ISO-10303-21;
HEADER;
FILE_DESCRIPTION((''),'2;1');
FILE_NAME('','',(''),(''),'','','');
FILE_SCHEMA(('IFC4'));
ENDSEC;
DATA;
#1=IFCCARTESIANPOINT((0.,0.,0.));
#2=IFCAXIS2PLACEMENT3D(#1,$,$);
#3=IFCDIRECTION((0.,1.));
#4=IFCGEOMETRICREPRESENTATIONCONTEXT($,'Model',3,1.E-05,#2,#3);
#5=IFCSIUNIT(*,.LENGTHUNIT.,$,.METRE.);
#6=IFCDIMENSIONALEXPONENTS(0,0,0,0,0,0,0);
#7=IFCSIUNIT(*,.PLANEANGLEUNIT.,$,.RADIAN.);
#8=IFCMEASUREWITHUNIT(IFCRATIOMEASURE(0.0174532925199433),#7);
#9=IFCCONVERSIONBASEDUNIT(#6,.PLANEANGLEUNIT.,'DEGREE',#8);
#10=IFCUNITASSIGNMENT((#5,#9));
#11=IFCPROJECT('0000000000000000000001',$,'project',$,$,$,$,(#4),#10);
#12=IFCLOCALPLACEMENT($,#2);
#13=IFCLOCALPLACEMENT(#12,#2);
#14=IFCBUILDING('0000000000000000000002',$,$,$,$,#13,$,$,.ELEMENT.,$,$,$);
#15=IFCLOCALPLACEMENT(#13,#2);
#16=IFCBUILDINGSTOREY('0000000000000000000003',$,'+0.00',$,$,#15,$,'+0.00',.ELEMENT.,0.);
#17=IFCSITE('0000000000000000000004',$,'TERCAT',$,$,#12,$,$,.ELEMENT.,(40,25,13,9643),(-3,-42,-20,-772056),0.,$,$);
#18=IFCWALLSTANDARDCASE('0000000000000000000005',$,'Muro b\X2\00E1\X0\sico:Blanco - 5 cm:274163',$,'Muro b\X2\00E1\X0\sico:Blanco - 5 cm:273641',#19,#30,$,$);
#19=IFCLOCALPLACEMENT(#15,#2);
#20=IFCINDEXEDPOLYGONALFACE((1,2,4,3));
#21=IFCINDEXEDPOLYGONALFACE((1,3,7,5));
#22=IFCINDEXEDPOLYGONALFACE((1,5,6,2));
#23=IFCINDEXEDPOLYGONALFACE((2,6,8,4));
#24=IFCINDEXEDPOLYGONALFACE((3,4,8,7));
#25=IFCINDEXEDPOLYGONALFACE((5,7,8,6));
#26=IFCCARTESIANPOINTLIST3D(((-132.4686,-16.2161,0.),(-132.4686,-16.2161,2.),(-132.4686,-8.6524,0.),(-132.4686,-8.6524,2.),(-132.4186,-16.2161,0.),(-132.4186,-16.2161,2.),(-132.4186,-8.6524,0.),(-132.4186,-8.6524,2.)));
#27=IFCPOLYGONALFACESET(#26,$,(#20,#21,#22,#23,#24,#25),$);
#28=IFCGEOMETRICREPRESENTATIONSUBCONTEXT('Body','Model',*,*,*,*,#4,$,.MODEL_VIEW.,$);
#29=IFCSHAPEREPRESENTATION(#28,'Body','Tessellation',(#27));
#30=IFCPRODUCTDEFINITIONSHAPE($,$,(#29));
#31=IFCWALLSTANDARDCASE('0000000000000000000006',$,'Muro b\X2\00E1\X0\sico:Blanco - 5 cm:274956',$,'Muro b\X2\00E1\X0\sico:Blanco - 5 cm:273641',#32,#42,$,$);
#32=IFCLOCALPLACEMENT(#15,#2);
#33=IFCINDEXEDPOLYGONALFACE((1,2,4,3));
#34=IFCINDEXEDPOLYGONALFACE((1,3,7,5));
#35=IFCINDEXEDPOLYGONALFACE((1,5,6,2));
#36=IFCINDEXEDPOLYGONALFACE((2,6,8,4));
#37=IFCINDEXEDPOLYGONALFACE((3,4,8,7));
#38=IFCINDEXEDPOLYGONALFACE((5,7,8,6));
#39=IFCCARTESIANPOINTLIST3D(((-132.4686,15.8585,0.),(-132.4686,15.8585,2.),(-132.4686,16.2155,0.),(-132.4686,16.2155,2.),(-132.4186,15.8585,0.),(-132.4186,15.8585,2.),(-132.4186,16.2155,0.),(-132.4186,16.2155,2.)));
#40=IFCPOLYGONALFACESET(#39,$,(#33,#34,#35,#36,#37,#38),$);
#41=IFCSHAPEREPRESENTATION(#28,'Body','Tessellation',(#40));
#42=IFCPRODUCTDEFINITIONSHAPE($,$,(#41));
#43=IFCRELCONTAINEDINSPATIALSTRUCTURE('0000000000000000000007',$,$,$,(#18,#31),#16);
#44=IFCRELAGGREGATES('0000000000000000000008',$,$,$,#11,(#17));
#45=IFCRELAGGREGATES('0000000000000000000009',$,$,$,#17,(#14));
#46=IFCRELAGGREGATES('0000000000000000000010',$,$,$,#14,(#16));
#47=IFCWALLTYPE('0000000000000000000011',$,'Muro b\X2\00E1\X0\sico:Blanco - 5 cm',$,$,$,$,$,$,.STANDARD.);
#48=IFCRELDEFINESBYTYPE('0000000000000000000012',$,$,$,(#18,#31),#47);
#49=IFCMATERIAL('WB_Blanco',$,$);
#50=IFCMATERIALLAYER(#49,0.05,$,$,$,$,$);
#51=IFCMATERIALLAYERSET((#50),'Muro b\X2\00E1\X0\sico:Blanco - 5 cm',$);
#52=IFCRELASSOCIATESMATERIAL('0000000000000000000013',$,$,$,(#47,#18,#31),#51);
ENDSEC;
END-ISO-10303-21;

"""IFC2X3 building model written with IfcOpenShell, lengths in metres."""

from ifc_helpers import new_model, entity, si_unit, converted_unit, direction, frame, frame_2d, origin, place, context, subcontext, project, spatial, rectangle, extrude, material, layer, layer_set, layer_usage, type_object, element, save


model = new_model("IFC2X3")

# Units and contexts
model_context = context("Model", 3, precision=1e-05, world=origin(), true_north=direction((0.0, 1.0)))
body_context = subcontext(model_context, "Body", "Model", "MODEL_VIEW")
ifc_project = project(units=[si_unit("LENGTHUNIT", "METRE"), converted_unit("PLANEANGLEUNIT", "DEGREE", entity("IfcRatioMeasure", 0.0174532925199433), si_unit("PLANEANGLEUNIT", "RADIAN"), dimensions=[0, 0, 0, 0, 0, 0, 0])], contexts=[model_context])

# Site, building, storey
site_placement = place(None, origin())
site = spatial("IfcSite", under=ifc_project, at=site_placement, Name="TERCAT", CompositionType="ELEMENT", RefLatitude=(40, 25, 13, 9643), RefLongitude=(-3, -42, -20, -772056), RefElevation=0.0)
building_placement = place(site_placement, origin())
building = spatial("IfcBuilding", under=site, at=building_placement, CompositionType="ELEMENT")
storey_placement = place(building_placement, origin())
storey = spatial("IfcBuildingStorey", under=building, at=storey_placement, Name="+0.00", LongName="+0.00", CompositionType="ELEMENT", Elevation=0.0)

# Walls
ifc_material_1 = material(Name="WB_Blanco")
ifc_layer_1 = layer(ifc_material_1, 0.05)
ifc_layer_set_1 = layer_set([ifc_layer_1], Name="Muro básico:Blanco - 5 cm")
ifc_layer_usage_1 = layer_usage(ifc_layer_set_1, "AXIS2", "POSITIVE", -0.025)
wall_type_1 = type_object("IfcWallType", Name="Muro básico:Blanco - 5 cm", PredefinedType="STANDARD", material=ifc_layer_set_1)
wall_1_placement = place(storey_placement, frame((-132.4436, -16.2161, 0.0), z_axis=(0.0, 0.0, 1.0), x_axis=(0.0, 1.0, 0.0)))
element("IfcWallStandardCase", 1, at=wall_1_placement, inside=storey, type_object=wall_type_1, material=ifc_layer_usage_1, Name="Muro básico:Blanco - 5 cm:274163", ObjectType="Muro básico:Blanco - 5 cm:273641", context=body_context, shape_type="SweptSolid", body=[
    extrude(rectangle(XDim=7.5638, YDim=0.05, at=frame_2d((3.7819, 0.0), x_axis=(-1.0, 0.0))), origin(), (0.0, 0.0, 1.0), 2.0),
])
ifc_layer_usage_2 = layer_usage(ifc_layer_set_1, "AXIS2", "POSITIVE", -0.025)
wall_2_placement = place(storey_placement, frame((-132.4436, 15.8585, 0.0), z_axis=(0.0, 0.0, 1.0), x_axis=(0.0, 1.0, 0.0)))
element("IfcWallStandardCase", 2, at=wall_2_placement, inside=storey, type_object=wall_type_1, material=ifc_layer_usage_2, Name="Muro básico:Blanco - 5 cm:274956", ObjectType="Muro básico:Blanco - 5 cm:273641", context=body_context, shape_type="SweptSolid", body=[
    extrude(rectangle(XDim=0.357, YDim=0.05, at=frame_2d((0.1785, 0.0), x_axis=(-1.0, 0.0))), origin(), (0.0, 0.0, 1.0), 2.0),
])

save(model, "model.ifc")
